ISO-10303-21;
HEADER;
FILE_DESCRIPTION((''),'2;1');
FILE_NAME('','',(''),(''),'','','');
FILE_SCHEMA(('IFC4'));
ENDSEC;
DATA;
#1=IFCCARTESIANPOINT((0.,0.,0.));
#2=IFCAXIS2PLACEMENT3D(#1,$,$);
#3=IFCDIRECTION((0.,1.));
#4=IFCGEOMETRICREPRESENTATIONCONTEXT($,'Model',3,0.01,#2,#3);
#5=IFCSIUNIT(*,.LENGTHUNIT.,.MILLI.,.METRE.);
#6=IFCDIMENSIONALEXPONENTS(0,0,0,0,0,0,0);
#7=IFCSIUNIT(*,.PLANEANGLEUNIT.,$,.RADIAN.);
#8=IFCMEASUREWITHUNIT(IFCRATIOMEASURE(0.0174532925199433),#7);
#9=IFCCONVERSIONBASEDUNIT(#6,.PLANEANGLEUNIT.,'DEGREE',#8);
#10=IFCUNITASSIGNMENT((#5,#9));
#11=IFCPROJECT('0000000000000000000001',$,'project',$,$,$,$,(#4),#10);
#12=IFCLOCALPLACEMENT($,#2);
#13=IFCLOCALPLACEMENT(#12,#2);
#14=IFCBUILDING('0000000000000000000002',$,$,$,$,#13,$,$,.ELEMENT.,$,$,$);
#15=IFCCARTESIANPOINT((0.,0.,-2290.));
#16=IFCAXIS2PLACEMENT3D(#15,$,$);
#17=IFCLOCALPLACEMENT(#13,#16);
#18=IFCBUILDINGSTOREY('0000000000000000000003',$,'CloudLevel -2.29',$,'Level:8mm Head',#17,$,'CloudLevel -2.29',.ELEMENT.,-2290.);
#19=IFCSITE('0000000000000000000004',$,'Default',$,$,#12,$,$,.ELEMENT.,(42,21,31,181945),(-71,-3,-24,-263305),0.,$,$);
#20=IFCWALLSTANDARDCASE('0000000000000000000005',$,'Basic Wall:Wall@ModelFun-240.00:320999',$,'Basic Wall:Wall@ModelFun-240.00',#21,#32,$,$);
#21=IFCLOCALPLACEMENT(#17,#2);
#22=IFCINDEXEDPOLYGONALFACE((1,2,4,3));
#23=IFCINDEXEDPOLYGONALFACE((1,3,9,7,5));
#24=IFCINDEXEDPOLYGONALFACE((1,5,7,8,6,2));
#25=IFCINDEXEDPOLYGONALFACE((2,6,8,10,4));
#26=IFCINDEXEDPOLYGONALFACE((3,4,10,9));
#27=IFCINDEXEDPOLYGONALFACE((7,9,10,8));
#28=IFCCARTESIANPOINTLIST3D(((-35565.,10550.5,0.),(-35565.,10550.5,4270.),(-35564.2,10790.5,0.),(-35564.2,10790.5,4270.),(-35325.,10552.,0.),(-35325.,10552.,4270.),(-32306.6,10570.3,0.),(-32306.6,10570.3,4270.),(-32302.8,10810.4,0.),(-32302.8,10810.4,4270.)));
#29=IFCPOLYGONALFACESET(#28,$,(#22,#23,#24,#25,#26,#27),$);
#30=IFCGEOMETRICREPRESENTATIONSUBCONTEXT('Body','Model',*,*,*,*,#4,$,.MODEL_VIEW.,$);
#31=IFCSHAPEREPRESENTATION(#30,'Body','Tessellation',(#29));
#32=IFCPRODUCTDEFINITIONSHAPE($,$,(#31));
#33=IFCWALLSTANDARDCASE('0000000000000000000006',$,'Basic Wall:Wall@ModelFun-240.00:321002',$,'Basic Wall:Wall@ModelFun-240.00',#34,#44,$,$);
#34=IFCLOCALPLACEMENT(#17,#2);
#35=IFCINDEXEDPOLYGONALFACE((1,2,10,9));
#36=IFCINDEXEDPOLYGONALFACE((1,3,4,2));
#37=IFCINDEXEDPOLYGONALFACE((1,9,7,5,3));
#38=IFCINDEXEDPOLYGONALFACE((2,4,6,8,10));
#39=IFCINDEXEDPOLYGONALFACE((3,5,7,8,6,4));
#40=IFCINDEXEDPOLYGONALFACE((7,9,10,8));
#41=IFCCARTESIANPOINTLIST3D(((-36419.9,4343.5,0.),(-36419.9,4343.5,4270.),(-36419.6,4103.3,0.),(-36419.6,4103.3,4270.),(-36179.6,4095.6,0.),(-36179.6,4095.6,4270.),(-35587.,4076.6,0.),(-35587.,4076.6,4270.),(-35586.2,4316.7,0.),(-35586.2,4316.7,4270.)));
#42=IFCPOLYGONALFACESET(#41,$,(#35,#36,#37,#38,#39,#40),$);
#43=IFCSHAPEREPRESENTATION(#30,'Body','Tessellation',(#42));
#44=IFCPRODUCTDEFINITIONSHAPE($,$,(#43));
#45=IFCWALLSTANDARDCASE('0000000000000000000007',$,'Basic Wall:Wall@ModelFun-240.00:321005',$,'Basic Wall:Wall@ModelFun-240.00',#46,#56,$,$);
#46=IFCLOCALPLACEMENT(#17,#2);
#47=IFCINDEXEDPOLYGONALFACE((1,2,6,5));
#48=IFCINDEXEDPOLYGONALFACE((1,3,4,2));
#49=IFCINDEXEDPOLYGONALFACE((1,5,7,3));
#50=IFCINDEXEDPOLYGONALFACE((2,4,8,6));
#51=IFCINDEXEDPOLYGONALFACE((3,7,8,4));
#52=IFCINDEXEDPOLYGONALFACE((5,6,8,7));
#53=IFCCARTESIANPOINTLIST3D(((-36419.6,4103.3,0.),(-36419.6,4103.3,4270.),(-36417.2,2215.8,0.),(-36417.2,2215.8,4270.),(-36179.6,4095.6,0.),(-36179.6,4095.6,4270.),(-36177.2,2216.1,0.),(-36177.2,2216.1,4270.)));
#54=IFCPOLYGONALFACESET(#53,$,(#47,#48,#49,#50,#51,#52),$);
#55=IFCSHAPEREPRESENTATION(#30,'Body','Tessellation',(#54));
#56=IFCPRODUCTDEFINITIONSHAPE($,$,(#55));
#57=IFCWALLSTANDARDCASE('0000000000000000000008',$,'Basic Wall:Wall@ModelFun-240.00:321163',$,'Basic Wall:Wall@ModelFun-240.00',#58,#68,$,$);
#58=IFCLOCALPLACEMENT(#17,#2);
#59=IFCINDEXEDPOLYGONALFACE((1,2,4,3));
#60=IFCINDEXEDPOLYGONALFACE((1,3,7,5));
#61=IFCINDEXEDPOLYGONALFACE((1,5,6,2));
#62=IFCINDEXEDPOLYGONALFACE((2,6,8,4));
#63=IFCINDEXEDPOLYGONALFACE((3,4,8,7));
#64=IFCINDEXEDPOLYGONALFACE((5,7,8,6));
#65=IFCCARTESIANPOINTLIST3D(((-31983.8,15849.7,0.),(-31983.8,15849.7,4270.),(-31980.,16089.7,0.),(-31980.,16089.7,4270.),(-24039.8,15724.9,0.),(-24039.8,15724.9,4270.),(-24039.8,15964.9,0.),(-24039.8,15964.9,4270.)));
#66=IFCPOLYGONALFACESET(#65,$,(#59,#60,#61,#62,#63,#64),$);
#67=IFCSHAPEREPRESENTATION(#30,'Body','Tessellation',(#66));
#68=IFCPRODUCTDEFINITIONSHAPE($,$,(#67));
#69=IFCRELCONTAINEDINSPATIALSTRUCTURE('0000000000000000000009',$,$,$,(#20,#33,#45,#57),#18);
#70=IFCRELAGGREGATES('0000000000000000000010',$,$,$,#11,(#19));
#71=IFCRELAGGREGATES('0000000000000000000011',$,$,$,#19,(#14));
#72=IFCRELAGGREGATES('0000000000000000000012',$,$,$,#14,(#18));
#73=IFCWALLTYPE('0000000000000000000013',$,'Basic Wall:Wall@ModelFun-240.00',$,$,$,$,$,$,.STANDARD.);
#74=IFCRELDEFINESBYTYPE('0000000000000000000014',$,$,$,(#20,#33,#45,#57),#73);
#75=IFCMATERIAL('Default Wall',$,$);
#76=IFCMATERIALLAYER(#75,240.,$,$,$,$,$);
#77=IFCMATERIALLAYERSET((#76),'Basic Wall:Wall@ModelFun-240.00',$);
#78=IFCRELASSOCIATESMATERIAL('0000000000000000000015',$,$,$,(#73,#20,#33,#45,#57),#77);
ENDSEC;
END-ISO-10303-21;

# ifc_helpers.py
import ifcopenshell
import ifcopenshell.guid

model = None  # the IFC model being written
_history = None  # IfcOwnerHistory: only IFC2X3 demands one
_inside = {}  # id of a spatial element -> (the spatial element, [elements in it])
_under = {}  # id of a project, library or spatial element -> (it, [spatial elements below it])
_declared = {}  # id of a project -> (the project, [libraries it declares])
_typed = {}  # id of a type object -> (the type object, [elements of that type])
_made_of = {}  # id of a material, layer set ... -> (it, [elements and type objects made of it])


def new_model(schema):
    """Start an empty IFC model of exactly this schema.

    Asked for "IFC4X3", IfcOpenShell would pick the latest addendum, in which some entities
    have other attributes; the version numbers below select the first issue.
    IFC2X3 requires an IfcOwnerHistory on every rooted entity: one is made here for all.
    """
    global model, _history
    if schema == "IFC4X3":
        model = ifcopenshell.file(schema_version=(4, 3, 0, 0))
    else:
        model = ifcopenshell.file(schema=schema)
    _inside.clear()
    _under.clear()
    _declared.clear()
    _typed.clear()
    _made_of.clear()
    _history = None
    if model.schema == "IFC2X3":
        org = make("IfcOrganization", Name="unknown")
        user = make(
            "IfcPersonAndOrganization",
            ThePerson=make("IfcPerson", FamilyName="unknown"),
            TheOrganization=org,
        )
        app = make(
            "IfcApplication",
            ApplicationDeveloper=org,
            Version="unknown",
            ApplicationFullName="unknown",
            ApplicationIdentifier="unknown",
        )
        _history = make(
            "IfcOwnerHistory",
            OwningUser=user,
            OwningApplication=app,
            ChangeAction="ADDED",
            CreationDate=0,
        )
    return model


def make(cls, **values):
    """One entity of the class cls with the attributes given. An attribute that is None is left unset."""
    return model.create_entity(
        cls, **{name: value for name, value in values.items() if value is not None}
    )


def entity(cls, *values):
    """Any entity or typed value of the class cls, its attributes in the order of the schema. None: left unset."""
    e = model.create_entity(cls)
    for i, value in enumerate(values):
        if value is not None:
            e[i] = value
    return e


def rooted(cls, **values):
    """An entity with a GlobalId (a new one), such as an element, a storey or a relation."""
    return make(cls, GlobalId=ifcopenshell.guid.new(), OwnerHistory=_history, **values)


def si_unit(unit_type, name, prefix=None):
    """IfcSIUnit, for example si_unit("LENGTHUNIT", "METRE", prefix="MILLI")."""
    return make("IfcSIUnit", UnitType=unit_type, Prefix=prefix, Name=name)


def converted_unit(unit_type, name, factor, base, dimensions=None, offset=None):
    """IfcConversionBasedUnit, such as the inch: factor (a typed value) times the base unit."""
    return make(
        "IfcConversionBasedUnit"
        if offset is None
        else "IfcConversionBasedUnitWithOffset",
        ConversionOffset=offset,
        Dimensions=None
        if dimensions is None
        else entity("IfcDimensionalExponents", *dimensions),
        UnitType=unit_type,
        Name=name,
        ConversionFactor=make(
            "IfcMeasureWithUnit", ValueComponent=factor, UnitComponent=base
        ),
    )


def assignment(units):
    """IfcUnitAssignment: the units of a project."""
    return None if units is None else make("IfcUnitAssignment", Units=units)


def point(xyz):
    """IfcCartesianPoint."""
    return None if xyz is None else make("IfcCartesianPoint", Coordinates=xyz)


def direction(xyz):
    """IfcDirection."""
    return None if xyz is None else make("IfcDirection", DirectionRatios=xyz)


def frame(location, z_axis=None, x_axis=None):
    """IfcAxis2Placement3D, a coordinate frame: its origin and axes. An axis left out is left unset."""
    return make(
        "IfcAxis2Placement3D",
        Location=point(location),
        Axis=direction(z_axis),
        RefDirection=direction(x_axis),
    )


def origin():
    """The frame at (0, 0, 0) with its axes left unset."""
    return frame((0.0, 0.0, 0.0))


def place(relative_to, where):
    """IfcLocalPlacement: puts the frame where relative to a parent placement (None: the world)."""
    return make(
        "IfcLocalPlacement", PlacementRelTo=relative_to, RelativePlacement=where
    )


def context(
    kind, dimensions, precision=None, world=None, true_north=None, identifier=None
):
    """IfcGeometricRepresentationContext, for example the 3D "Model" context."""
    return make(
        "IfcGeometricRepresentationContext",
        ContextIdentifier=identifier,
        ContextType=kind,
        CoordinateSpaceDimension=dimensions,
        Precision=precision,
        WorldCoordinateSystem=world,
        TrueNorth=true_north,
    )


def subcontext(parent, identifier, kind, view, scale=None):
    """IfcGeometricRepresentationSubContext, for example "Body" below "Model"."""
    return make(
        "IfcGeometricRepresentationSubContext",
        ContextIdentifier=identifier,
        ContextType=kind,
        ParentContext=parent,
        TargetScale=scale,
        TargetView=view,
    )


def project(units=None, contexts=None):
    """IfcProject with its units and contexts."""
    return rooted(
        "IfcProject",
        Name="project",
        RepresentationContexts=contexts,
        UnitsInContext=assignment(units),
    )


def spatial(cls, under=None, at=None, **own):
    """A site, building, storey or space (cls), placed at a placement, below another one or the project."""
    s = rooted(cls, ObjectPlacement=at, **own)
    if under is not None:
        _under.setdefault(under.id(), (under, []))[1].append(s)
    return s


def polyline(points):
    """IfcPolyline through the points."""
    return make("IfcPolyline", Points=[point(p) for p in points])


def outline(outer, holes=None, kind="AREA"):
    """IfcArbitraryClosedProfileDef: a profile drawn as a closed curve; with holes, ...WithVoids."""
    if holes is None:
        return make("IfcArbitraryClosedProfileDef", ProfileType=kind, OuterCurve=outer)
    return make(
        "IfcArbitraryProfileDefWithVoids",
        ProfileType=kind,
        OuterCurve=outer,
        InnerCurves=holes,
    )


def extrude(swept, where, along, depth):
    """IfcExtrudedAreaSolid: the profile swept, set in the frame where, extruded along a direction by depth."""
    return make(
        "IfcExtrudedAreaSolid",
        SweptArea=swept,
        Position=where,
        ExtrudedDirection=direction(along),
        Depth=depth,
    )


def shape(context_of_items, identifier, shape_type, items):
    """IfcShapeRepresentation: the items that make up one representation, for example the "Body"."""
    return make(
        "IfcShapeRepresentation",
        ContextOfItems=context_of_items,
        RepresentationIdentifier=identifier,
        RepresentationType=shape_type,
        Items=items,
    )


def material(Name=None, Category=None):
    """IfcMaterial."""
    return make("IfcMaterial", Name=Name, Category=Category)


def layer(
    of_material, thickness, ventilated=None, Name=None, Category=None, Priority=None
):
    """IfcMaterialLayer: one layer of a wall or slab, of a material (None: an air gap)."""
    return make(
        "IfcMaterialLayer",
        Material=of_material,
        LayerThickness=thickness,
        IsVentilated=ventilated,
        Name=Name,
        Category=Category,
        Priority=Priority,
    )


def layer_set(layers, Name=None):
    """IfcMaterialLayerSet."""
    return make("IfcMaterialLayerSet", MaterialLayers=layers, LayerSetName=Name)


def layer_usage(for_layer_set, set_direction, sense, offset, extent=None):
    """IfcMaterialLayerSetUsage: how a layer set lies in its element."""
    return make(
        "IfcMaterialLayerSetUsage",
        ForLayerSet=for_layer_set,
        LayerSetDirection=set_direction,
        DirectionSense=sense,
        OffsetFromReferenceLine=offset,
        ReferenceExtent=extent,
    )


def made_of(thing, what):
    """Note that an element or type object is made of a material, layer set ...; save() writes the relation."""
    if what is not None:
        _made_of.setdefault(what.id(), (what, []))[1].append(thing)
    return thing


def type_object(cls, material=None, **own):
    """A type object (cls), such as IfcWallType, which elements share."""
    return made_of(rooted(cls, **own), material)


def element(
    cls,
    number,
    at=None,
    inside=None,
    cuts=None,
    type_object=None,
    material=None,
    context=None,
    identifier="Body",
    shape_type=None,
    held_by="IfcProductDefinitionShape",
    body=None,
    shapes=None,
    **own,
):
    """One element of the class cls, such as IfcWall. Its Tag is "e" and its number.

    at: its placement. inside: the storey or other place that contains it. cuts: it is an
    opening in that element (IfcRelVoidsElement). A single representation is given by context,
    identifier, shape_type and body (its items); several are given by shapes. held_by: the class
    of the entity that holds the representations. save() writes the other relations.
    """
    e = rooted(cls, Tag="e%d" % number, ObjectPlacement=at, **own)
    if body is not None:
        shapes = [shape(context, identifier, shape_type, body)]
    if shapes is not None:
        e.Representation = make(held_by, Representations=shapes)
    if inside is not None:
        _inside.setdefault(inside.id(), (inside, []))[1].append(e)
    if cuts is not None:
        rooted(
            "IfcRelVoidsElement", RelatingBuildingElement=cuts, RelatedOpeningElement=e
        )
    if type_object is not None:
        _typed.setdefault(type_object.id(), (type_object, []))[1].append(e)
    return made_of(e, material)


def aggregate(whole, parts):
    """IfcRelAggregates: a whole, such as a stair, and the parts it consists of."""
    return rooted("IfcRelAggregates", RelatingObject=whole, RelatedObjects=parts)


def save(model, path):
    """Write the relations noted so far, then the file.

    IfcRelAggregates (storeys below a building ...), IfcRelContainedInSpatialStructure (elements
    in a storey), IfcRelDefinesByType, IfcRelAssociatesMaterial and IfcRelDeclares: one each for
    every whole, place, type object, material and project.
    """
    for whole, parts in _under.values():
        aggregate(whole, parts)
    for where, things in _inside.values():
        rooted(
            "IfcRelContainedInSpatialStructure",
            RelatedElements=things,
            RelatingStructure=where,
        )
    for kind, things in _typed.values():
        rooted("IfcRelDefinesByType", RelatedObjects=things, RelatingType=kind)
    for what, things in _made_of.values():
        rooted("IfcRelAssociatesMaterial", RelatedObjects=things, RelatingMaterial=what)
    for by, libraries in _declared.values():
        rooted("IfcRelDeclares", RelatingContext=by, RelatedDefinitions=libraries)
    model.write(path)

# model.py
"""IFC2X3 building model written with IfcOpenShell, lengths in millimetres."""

from ifc_helpers import new_model, entity, si_unit, converted_unit, direction, frame, origin, place, context, subcontext, project, spatial, polyline, outline, extrude, material, layer, layer_set, layer_usage, type_object, element, save


model = new_model("IFC2X3")

# Units and contexts
model_context = context("Model", 3, precision=0.01, world=origin(), true_north=direction((0.0, 1.0)))
body_context = subcontext(model_context, "Body", "Model", "MODEL_VIEW")
ifc_project = project(units=[si_unit("LENGTHUNIT", "METRE", prefix="MILLI"), converted_unit("PLANEANGLEUNIT", "DEGREE", entity("IfcRatioMeasure", 0.0174532925199433), si_unit("PLANEANGLEUNIT", "RADIAN"), dimensions=[0, 0, 0, 0, 0, 0, 0])], contexts=[model_context])

# Site, building, storey
site_placement = place(None, origin())
site = spatial("IfcSite", under=ifc_project, at=site_placement, Name="Default", CompositionType="ELEMENT", RefLatitude=(42, 21, 31, 181945), RefLongitude=(-71, -3, -24, -263305), RefElevation=0.0)
building_placement = place(site_placement, origin())
building = spatial("IfcBuilding", under=site, at=building_placement, CompositionType="ELEMENT")
storey_placement = place(building_placement, frame((0.0, 0.0, -2290.0)))
storey = spatial("IfcBuildingStorey", under=building, at=storey_placement, Name="CloudLevel -2.29", ObjectType="Level:8mm Head", LongName="CloudLevel -2.29", CompositionType="ELEMENT", Elevation=-2290.0)

# Shared definitions
ifc_material_1 = material(Name="Default Wall")

# Walls
ifc_layer = layer(ifc_material_1, 240.0)
ifc_layer_set = layer_set([ifc_layer], Name="Basic Wall:Wall@ModelFun-240.00")
wall_type = type_object("IfcWallType", Name="Basic Wall:Wall@ModelFun-240.00", PredefinedType="STANDARD", material=ifc_layer_set)
ifc_layer_usage_1 = layer_usage(ifc_layer_set, "AXIS2", "NEGATIVE", 120.0)
wall_1_placement = place(storey_placement, frame((-35565.7, 10670.5, 0.0), z_axis=(0.0, 0.0, 1.0), x_axis=(0.999981, 0.006083, 0.0)))
element("IfcWallStandardCase", 1, at=wall_1_placement, inside=storey, type_object=wall_type, material=ifc_layer_usage_1, Name="Basic Wall:Wall@ModelFun-240.00:320999", ObjectType="Basic Wall:Wall@ModelFun-240.00", context=body_context, shape_type="SweptSolid", body=[
    extrude(outline(polyline([(3258.5, -120.0), (3263.7, 120.0), (2.3, 120.0), (0.0, -120.0), (240.0, -120.0), (3258.5, -120.0)])), origin(), (0.0, 0.0, 1.0), 4270.0),
])
ifc_layer_usage_2 = layer_usage(ifc_layer_set, "AXIS2", "NEGATIVE", 120.0)
wall_2_placement = place(storey_placement, frame((-35583.2, 4196.6, 0.0), z_axis=(0.0, 0.0, 1.0), x_axis=(-0.999486, 0.032047, 0.0)))
element("IfcWallStandardCase", 2, at=wall_2_placement, inside=storey, type_object=wall_type, material=ifc_layer_usage_2, Name="Basic Wall:Wall@ModelFun-240.00:321002", ObjectType="Basic Wall:Wall@ModelFun-240.00", context=body_context, shape_type="SweptSolid", body=[
    extrude(outline(polyline([(841.0, -120.0), (833.0, 120.0), (592.9, 120.0), (0.0, 120.0), (6.9, -120.0), (841.0, -120.0)])), origin(), (0.0, 0.0, 1.0), 4270.0),
])
ifc_layer_usage_3 = layer_usage(ifc_layer_set, "AXIS2", "NEGATIVE", 120.0)
wall_3_placement = place(storey_placement, frame((-36299.6, 4103.5, 0.0), z_axis=(0.0, 0.0, 1.0), x_axis=(0.00126, -0.999999, 0.0)))
element("IfcWallStandardCase", 3, at=wall_3_placement, inside=storey, type_object=wall_type, material=ifc_layer_usage_3, Name="Basic Wall:Wall@ModelFun-240.00:321005", ObjectType="Basic Wall:Wall@ModelFun-240.00", context=body_context, shape_type="SweptSolid", body=[
    extrude(outline(polyline([(1887.5, -120.0), (1887.5, 120.0), (8.0, 120.0), (0.0, -120.0), (1887.5, -120.0)])), origin(), (0.0, 0.0, 1.0), 4270.0),
])
ifc_layer_usage_4 = layer_usage(ifc_layer_set, "AXIS2", "NEGATIVE", 120.0)
wall_4_placement = place(storey_placement, frame((-31981.9, 15969.7, 0.0), z_axis=(0.0, 0.0, 1.0), x_axis=(0.999877, -0.015713, 0.0)))
element("IfcWallStandardCase", 4, at=wall_4_placement, inside=storey, type_object=wall_type, material=ifc_layer_usage_4, Name="Basic Wall:Wall@ModelFun-240.00:321163", ObjectType="Basic Wall:Wall@ModelFun-240.00", context=body_context, shape_type="SweptSolid", body=[
    extrude(outline(polyline([(7945.0, -120.0), (7941.3, 120.0), (0.0, 120.0), (0.0, -120.0), (7945.0, -120.0)])), origin(), (0.0, 0.0, 1.0), 4270.0),
])

save(model, "model.ifc")
